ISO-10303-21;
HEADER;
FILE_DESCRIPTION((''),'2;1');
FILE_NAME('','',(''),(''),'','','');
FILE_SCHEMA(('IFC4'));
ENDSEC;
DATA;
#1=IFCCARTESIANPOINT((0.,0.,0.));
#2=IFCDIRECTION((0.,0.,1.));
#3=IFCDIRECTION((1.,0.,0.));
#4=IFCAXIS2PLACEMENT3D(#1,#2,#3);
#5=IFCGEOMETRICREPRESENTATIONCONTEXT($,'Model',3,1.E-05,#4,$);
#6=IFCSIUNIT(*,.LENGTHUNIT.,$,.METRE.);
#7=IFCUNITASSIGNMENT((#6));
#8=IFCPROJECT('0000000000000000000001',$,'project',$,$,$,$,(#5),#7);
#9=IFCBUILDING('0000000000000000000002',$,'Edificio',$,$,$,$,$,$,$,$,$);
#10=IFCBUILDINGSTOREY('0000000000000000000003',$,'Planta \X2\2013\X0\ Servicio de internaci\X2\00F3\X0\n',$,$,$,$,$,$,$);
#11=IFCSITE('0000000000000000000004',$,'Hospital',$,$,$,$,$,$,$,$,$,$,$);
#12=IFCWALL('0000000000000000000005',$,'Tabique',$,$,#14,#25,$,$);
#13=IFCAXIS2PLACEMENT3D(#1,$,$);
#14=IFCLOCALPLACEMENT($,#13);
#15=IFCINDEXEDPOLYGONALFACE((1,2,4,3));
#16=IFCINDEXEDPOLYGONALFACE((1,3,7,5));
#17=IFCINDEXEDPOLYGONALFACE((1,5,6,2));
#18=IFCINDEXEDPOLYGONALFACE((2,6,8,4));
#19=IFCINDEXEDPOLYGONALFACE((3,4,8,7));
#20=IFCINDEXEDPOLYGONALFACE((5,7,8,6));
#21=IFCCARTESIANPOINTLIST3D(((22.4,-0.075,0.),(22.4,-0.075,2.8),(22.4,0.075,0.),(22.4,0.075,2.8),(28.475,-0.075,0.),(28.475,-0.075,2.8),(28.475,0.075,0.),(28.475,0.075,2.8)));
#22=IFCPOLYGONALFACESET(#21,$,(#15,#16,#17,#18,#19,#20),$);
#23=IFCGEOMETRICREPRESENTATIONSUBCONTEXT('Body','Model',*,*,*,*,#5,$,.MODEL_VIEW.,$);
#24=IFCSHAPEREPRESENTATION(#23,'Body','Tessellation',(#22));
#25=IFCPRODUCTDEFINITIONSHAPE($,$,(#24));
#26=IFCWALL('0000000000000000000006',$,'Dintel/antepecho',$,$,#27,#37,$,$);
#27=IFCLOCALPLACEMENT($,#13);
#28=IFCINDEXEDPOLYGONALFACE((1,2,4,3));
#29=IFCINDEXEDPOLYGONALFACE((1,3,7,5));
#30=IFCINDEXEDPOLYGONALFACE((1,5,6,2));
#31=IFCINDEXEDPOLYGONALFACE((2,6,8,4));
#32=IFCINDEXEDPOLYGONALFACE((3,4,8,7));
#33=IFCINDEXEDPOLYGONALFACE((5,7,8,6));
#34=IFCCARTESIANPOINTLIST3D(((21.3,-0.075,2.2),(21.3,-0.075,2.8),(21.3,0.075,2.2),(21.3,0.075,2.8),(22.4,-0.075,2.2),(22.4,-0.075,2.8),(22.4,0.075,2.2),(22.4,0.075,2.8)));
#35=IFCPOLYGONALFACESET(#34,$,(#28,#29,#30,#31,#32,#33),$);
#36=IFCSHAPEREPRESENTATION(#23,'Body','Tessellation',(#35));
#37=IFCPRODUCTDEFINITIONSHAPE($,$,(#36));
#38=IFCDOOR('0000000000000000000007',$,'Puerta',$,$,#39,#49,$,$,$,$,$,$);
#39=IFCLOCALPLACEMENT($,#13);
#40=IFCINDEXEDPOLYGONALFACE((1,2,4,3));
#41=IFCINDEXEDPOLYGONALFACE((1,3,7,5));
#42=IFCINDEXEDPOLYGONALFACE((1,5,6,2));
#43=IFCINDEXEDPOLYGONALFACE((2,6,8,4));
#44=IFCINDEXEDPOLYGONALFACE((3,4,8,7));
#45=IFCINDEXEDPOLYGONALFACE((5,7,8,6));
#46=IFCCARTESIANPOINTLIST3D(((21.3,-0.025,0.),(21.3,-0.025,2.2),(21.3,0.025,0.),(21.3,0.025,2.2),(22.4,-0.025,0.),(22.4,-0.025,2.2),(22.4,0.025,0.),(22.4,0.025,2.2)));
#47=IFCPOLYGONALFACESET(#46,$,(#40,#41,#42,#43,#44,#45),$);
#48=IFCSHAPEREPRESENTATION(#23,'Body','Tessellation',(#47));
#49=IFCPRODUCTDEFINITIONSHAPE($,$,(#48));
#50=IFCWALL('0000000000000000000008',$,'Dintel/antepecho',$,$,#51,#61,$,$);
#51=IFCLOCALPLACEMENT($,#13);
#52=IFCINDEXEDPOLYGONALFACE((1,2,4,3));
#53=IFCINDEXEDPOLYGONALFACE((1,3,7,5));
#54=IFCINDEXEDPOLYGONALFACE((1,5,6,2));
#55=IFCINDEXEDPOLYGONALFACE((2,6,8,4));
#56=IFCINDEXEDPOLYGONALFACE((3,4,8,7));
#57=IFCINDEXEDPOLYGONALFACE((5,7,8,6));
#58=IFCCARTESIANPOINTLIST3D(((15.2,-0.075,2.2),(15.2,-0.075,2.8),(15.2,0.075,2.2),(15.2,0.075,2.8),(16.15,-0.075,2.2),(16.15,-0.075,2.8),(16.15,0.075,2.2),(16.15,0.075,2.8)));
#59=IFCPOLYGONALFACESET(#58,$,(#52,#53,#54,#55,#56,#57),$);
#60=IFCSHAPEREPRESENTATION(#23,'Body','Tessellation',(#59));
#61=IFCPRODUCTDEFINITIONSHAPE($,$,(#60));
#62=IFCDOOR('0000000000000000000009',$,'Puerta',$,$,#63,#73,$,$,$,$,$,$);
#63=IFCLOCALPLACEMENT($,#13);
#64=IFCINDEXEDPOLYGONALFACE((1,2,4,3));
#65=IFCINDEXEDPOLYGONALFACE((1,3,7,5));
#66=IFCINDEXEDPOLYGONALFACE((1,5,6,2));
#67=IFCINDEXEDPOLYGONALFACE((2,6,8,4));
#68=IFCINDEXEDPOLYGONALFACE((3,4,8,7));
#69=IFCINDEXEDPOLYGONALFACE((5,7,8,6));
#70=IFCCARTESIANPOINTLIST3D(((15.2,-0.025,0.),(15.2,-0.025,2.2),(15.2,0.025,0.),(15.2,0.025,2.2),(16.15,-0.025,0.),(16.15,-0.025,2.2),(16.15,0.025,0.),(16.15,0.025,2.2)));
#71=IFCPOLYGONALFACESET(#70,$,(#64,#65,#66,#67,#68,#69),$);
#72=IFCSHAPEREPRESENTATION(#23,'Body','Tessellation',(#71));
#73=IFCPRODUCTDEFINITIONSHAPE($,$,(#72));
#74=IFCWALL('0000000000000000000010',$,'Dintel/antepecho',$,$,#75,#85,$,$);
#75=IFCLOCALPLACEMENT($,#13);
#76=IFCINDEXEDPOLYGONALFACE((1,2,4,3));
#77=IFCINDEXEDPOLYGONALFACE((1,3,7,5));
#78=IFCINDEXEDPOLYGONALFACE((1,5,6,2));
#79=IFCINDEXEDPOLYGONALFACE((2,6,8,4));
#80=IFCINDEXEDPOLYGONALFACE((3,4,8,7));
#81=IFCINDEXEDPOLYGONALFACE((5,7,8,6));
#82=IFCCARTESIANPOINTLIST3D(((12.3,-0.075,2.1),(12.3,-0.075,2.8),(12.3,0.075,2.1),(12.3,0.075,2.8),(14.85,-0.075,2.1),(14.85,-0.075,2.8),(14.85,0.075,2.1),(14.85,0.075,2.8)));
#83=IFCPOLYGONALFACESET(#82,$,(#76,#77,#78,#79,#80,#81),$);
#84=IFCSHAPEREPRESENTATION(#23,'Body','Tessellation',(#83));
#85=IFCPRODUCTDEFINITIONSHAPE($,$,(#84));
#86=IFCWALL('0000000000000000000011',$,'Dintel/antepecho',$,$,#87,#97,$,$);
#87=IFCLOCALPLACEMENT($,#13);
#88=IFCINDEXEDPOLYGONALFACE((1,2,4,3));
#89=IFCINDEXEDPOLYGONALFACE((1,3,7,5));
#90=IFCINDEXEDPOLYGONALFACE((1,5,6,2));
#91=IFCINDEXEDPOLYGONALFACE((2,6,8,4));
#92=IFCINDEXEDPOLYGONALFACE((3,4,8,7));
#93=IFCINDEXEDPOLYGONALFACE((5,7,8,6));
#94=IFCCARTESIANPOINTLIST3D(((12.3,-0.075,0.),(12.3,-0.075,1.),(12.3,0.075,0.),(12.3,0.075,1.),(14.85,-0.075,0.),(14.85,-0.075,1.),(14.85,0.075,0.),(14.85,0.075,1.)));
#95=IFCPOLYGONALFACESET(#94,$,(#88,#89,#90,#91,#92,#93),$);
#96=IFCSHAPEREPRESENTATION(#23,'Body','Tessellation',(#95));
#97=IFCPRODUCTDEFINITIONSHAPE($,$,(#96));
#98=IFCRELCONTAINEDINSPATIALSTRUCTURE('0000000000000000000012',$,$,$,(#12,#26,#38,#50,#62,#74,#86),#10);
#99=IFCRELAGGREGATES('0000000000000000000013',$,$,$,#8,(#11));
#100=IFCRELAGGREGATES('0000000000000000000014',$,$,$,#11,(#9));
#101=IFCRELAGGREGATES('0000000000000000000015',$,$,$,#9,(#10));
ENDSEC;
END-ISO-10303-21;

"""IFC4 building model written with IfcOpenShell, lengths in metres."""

from ifc_helpers import new_model, si_unit, frame, origin_with_axes, context, subcontext, project, spatial, line, indexed_curve, outline, extrude, element, save


model = new_model("IFC4")

# Units and contexts
model_context = context("Model", 3, precision=1e-05, world=origin_with_axes())
body_context = subcontext(model_context, "Body", "Model", "MODEL_VIEW")
ifc_project = project(units=[si_unit("LENGTHUNIT", "METRE")], contexts=[model_context])

# Site, building, storey
site = spatial("IfcSite", under=ifc_project, Name="Hospital")
building = spatial("IfcBuilding", under=site, Name="Edificio")
storey = spatial("IfcBuildingStorey", under=building, Name="Planta – Servicio de internación")

# Walls
element("IfcWall", 1, inside=storey, Name="Tabique", context=body_context, shape_type="SweptSolid", body=[
    extrude(outline(indexed_curve([(0.0, 0.0), (6.075, 0.0), (6.075, 0.15), (0.0, 0.15)], segments=[line(1, 2, 3, 4, 1)])), frame((22.4, -0.075, 0.0), z_axis=(0.0, 0.0, 1.0), x_axis=(1.0, 0.0, 0.0)), (0.0, 0.0, 1.0), 2.8),
])
element("IfcWall", 2, inside=storey, Name="Dintel/antepecho", context=body_context, shape_type="SweptSolid", body=[
    extrude(outline(indexed_curve([(0.0, 0.0), (1.1, 0.0), (1.1, 0.15), (0.0, 0.15)], segments=[line(1, 2, 3, 4, 1)])), frame((21.3, -0.075, 2.2), z_axis=(0.0, 0.0, 1.0), x_axis=(1.0, 0.0, 0.0)), (0.0, 0.0, 1.0), 0.6),
])

# Door
element("IfcDoor", 3, inside=storey, Name="Puerta", context=body_context, shape_type="SweptSolid", body=[
    extrude(outline(indexed_curve([(0.0, 0.0), (1.1, 0.0), (1.1, 0.05), (0.0, 0.05)], segments=[line(1, 2, 3, 4, 1)])), frame((21.3, -0.025, 0.0), z_axis=(0.0, 0.0, 1.0), x_axis=(1.0, 0.0, 0.0)), (0.0, 0.0, 1.0), 2.2),
])

# Wall
element("IfcWall", 4, inside=storey, Name="Dintel/antepecho", context=body_context, shape_type="SweptSolid", body=[
    extrude(outline(indexed_curve([(0.0, 0.0), (0.95, 0.0), (0.95, 0.15), (0.0, 0.15)], segments=[line(1, 2, 3, 4, 1)])), frame((15.2, -0.075, 2.2), z_axis=(0.0, 0.0, 1.0), x_axis=(1.0, 0.0, 0.0)), (0.0, 0.0, 1.0), 0.6),
])

# Door
element("IfcDoor", 5, inside=storey, Name="Puerta", context=body_context, shape_type="SweptSolid", body=[
    extrude(outline(indexed_curve([(0.0, 0.0), (0.95, 0.0), (0.95, 0.05), (0.0, 0.05)], segments=[line(1, 2, 3, 4, 1)])), frame((15.2, -0.025, 0.0), z_axis=(0.0, 0.0, 1.0), x_axis=(1.0, 0.0, 0.0)), (0.0, 0.0, 1.0), 2.2),
])

# Walls
element("IfcWall", 6, inside=storey, Name="Dintel/antepecho", context=body_context, shape_type="SweptSolid", body=[
    extrude(outline(indexed_curve([(0.0, 0.0), (2.55, 0.0), (2.55, 0.15), (0.0, 0.15)], segments=[line(1, 2, 3, 4, 1)])), frame((12.3, -0.075, 2.1), z_axis=(0.0, 0.0, 1.0), x_axis=(1.0, 0.0, 0.0)), (0.0, 0.0, 1.0), 0.7),
])
element("IfcWall", 7, inside=storey, Name="Dintel/antepecho", context=body_context, shape_type="SweptSolid", body=[
    extrude(outline(indexed_curve([(0.0, 0.0), (2.55, 0.0), (2.55, 0.15), (0.0, 0.15)], segments=[line(1, 2, 3, 4, 1)])), frame((12.3, -0.075, 0.0), z_axis=(0.0, 0.0, 1.0), x_axis=(1.0, 0.0, 0.0)), (0.0, 0.0, 1.0), 1.0),
])

save(model, "model.ifc")
